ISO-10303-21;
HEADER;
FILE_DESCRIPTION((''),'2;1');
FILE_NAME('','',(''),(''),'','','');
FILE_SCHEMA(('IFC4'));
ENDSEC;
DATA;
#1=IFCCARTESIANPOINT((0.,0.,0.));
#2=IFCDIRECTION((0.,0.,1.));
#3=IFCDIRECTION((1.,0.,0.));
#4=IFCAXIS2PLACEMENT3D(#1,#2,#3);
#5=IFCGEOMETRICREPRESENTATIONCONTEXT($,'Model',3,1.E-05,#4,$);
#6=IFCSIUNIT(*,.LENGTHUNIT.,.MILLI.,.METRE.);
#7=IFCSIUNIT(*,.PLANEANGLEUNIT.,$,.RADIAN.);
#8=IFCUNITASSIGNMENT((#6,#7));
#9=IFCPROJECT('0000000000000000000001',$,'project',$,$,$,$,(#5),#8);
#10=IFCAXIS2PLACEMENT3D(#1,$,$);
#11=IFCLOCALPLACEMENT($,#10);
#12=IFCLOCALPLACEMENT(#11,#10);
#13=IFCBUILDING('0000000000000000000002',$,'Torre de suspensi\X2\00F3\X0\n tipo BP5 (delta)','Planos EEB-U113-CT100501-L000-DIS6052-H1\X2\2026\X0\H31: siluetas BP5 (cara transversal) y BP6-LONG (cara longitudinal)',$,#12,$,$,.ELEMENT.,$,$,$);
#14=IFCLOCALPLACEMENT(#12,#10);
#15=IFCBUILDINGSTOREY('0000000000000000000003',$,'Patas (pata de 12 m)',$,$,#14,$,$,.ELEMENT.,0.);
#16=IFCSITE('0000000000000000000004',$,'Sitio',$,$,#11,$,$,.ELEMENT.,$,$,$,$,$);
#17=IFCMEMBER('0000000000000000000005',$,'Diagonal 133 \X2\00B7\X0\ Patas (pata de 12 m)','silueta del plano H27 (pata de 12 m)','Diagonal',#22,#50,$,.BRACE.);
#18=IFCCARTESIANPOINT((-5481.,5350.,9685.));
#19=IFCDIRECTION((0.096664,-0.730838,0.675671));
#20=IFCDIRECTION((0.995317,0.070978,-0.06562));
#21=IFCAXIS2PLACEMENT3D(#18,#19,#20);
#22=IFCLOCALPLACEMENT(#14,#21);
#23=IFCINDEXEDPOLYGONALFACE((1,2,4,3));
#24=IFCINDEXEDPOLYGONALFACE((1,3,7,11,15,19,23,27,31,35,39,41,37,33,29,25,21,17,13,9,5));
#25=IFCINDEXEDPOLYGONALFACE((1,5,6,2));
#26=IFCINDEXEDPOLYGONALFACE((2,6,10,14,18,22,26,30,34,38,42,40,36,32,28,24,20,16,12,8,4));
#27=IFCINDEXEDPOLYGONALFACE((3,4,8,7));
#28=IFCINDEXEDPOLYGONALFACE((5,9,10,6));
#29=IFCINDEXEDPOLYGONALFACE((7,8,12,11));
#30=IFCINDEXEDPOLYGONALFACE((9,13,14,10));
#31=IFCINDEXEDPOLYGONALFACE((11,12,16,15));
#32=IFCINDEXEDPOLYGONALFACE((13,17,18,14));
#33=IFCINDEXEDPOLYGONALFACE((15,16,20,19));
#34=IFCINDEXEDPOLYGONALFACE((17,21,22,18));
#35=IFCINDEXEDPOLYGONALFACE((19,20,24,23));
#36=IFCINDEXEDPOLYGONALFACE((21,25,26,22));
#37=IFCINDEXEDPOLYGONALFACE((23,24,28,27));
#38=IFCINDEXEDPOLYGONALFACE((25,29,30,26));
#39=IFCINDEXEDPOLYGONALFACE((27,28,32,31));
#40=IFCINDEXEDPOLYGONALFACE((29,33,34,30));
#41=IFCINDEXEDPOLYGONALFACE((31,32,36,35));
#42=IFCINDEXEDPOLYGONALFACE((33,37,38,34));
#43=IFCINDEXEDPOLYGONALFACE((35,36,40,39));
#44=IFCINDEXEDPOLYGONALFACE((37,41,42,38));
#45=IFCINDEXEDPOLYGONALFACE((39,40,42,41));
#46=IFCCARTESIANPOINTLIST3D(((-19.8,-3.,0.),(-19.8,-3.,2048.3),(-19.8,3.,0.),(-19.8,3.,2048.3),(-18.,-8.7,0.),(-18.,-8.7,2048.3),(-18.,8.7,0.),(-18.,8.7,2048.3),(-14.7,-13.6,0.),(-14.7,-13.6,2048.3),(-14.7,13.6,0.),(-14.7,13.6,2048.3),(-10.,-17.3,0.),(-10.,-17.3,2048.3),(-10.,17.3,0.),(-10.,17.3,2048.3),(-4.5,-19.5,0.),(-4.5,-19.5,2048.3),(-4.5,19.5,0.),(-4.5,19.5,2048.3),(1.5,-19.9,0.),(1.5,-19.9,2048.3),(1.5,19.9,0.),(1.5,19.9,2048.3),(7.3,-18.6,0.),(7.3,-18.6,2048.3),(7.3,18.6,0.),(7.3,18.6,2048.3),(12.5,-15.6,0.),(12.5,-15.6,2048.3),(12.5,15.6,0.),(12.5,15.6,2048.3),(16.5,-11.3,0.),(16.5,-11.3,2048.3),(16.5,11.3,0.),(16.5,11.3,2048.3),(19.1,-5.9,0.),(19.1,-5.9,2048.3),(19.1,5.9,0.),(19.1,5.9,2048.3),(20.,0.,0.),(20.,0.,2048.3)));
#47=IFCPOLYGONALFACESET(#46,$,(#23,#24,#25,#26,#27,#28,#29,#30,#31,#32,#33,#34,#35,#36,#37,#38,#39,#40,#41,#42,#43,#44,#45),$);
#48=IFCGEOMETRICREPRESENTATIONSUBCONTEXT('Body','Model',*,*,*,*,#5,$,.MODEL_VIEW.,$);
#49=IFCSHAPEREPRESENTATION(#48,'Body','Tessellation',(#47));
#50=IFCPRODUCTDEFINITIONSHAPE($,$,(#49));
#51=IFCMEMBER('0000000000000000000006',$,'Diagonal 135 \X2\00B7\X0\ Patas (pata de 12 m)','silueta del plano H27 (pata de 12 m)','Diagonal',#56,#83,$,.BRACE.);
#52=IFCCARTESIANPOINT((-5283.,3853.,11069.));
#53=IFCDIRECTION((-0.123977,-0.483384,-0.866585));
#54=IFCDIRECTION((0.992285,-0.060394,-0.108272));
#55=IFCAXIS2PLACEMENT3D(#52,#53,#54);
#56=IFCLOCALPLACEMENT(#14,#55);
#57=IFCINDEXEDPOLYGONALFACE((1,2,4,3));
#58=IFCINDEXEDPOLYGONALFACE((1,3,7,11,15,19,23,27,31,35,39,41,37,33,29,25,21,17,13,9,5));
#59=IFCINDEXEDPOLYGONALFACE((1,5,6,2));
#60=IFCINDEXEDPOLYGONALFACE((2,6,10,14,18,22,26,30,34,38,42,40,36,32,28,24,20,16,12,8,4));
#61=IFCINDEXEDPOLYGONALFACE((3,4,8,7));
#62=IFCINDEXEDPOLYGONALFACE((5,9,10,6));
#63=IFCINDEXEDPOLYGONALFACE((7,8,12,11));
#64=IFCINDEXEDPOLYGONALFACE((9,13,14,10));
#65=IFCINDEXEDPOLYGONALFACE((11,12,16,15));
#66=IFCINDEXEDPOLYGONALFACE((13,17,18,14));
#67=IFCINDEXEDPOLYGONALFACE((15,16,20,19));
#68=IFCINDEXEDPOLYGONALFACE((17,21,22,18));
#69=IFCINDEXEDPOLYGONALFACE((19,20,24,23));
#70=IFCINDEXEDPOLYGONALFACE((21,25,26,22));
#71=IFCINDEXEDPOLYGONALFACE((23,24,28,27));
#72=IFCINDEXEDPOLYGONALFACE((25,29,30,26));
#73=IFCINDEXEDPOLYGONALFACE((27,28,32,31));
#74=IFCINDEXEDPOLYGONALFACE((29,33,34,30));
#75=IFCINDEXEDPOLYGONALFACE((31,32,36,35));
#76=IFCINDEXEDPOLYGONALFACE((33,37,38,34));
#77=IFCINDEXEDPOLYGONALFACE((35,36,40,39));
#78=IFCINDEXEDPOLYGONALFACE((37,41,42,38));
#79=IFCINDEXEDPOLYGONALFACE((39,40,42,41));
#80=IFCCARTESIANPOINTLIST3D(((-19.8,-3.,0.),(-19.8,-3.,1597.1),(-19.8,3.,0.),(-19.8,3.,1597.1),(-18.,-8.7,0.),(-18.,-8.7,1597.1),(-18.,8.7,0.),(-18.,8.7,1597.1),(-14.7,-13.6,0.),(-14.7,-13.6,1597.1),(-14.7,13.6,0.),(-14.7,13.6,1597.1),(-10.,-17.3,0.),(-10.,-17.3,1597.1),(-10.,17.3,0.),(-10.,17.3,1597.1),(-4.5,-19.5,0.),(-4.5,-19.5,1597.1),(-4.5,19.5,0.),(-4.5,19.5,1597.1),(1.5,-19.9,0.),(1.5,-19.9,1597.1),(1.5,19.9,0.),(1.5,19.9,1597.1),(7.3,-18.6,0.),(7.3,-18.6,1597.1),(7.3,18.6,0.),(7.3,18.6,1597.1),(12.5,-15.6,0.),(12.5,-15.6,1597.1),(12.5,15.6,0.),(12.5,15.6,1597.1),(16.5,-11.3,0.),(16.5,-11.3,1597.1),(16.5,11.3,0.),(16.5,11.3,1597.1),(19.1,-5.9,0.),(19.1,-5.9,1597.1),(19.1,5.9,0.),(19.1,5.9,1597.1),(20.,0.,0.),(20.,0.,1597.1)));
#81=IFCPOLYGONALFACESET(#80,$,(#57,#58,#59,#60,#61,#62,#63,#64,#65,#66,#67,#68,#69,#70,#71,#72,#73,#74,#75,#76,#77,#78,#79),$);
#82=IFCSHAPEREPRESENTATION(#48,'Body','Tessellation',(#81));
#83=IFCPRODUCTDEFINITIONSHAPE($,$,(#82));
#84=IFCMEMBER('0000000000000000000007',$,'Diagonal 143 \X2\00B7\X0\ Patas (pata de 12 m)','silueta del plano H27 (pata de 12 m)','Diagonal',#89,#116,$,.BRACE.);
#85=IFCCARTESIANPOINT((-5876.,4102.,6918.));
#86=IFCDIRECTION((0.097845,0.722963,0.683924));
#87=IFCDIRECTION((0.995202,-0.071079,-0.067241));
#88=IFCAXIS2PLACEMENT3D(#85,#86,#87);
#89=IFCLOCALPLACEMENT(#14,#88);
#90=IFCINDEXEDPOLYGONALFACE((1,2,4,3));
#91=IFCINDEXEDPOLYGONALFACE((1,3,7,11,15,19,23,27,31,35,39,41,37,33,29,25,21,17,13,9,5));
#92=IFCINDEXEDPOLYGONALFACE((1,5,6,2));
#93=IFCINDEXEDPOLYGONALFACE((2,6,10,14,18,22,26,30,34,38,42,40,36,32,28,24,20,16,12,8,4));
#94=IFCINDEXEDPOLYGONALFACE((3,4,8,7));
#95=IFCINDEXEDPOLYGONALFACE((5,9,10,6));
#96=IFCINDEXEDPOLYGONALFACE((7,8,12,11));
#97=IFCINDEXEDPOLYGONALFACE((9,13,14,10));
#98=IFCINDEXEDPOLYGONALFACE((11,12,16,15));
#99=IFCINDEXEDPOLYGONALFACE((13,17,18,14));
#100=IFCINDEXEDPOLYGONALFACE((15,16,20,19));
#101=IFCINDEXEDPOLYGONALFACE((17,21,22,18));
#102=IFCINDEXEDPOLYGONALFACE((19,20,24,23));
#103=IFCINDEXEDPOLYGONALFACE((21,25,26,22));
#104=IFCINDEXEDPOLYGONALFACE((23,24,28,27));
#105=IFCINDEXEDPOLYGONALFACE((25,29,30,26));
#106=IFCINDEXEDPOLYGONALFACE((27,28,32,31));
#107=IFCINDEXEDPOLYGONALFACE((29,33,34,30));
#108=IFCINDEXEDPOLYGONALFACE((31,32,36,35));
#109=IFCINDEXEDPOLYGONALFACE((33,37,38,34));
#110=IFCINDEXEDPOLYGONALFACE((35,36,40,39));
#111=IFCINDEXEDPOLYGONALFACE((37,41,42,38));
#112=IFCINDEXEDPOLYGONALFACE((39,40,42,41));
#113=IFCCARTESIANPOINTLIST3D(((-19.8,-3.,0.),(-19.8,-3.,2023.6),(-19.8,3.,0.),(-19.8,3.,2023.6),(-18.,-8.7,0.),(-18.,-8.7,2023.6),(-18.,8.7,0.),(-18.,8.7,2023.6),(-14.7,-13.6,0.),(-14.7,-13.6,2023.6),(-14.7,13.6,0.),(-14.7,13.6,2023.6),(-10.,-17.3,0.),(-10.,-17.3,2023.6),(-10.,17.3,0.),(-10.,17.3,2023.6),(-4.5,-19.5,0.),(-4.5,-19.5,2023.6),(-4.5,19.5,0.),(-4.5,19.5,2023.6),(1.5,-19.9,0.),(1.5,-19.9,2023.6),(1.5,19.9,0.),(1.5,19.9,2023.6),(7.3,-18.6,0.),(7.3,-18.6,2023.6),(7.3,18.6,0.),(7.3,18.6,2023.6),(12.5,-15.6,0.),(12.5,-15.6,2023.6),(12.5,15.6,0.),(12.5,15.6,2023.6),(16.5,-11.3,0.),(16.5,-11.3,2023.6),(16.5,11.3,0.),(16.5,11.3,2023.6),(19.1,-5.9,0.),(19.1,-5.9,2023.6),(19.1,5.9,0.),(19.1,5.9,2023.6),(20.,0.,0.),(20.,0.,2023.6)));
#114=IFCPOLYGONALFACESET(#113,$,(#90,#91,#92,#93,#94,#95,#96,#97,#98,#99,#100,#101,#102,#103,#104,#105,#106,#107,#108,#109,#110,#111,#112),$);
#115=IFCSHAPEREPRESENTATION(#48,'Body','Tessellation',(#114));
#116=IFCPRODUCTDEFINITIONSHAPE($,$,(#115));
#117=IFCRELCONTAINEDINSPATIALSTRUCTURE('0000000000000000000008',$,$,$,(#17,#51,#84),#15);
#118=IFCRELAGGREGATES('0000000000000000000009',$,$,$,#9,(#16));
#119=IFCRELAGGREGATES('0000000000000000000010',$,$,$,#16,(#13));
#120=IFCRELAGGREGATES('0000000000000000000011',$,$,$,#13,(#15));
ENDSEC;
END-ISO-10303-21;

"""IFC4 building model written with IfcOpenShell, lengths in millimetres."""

from ifc_helpers import new_model, si_unit, frame, origin, origin_with_axes, place, context, subcontext, project, spatial, circle, extrude, element, save


model = new_model("IFC4")

# Units and contexts
model_context = context("Model", 3, precision=1e-05, world=origin_with_axes())
body_context = subcontext(model_context, "Body", "Model", "MODEL_VIEW")
ifc_project = project(units=[si_unit("LENGTHUNIT", "METRE", prefix="MILLI"), si_unit("PLANEANGLEUNIT", "RADIAN")], contexts=[model_context])

# Site, building, storey
site_placement = place(None, origin())
site = spatial("IfcSite", under=ifc_project, at=site_placement, Name="Sitio", CompositionType="ELEMENT")
building_placement = place(site_placement, origin())
building = spatial("IfcBuilding", under=site, at=building_placement, Name="Torre de suspensión tipo BP5 (delta)", Description="Planos EEB-U113-CT100501-L000-DIS6052-H1…H31: siluetas BP5 (cara transversal) y BP6-LONG (cara longitudinal)", CompositionType="ELEMENT")
storey_placement = place(building_placement, origin())
storey = spatial("IfcBuildingStorey", under=building, at=storey_placement, Name="Patas (pata de 12 m)", CompositionType="ELEMENT", Elevation=0.0)

# Members
member_1_placement = place(storey_placement, frame((-5481.0, 5350.0, 9685.0), z_axis=(0.096664, -0.730838, 0.675671), x_axis=(0.995317, 0.070978, -0.06562)))
element("IfcMember", 1, at=member_1_placement, inside=storey, Name="Diagonal 133 · Patas (pata de 12 m)", Description="silueta del plano H27 (pata de 12 m)", ObjectType="Diagonal", PredefinedType="BRACE", context=body_context, shape_type="SweptSolid", body=[
    extrude(circle(Radius=20.0), None, (0.0, 0.0, 1.0), 2048.3),
])
member_2_placement = place(storey_placement, frame((-5283.0, 3853.0, 11069.0), z_axis=(-0.123977, -0.483384, -0.866585), x_axis=(0.992285, -0.060394, -0.108272)))
element("IfcMember", 2, at=member_2_placement, inside=storey, Name="Diagonal 135 · Patas (pata de 12 m)", Description="silueta del plano H27 (pata de 12 m)", ObjectType="Diagonal", PredefinedType="BRACE", context=body_context, shape_type="SweptSolid", body=[
    extrude(circle(Radius=20.0), None, (0.0, 0.0, 1.0), 1597.1),
])
member_3_placement = place(storey_placement, frame((-5876.0, 4102.0, 6918.0), z_axis=(0.097845, 0.722963, 0.683924), x_axis=(0.995202, -0.071079, -0.067241)))
element("IfcMember", 3, at=member_3_placement, inside=storey, Name="Diagonal 143 · Patas (pata de 12 m)", Description="silueta del plano H27 (pata de 12 m)", ObjectType="Diagonal", PredefinedType="BRACE", context=body_context, shape_type="SweptSolid", body=[
    extrude(circle(Radius=20.0), None, (0.0, 0.0, 1.0), 2023.6),
])

save(model, "model.ifc")
